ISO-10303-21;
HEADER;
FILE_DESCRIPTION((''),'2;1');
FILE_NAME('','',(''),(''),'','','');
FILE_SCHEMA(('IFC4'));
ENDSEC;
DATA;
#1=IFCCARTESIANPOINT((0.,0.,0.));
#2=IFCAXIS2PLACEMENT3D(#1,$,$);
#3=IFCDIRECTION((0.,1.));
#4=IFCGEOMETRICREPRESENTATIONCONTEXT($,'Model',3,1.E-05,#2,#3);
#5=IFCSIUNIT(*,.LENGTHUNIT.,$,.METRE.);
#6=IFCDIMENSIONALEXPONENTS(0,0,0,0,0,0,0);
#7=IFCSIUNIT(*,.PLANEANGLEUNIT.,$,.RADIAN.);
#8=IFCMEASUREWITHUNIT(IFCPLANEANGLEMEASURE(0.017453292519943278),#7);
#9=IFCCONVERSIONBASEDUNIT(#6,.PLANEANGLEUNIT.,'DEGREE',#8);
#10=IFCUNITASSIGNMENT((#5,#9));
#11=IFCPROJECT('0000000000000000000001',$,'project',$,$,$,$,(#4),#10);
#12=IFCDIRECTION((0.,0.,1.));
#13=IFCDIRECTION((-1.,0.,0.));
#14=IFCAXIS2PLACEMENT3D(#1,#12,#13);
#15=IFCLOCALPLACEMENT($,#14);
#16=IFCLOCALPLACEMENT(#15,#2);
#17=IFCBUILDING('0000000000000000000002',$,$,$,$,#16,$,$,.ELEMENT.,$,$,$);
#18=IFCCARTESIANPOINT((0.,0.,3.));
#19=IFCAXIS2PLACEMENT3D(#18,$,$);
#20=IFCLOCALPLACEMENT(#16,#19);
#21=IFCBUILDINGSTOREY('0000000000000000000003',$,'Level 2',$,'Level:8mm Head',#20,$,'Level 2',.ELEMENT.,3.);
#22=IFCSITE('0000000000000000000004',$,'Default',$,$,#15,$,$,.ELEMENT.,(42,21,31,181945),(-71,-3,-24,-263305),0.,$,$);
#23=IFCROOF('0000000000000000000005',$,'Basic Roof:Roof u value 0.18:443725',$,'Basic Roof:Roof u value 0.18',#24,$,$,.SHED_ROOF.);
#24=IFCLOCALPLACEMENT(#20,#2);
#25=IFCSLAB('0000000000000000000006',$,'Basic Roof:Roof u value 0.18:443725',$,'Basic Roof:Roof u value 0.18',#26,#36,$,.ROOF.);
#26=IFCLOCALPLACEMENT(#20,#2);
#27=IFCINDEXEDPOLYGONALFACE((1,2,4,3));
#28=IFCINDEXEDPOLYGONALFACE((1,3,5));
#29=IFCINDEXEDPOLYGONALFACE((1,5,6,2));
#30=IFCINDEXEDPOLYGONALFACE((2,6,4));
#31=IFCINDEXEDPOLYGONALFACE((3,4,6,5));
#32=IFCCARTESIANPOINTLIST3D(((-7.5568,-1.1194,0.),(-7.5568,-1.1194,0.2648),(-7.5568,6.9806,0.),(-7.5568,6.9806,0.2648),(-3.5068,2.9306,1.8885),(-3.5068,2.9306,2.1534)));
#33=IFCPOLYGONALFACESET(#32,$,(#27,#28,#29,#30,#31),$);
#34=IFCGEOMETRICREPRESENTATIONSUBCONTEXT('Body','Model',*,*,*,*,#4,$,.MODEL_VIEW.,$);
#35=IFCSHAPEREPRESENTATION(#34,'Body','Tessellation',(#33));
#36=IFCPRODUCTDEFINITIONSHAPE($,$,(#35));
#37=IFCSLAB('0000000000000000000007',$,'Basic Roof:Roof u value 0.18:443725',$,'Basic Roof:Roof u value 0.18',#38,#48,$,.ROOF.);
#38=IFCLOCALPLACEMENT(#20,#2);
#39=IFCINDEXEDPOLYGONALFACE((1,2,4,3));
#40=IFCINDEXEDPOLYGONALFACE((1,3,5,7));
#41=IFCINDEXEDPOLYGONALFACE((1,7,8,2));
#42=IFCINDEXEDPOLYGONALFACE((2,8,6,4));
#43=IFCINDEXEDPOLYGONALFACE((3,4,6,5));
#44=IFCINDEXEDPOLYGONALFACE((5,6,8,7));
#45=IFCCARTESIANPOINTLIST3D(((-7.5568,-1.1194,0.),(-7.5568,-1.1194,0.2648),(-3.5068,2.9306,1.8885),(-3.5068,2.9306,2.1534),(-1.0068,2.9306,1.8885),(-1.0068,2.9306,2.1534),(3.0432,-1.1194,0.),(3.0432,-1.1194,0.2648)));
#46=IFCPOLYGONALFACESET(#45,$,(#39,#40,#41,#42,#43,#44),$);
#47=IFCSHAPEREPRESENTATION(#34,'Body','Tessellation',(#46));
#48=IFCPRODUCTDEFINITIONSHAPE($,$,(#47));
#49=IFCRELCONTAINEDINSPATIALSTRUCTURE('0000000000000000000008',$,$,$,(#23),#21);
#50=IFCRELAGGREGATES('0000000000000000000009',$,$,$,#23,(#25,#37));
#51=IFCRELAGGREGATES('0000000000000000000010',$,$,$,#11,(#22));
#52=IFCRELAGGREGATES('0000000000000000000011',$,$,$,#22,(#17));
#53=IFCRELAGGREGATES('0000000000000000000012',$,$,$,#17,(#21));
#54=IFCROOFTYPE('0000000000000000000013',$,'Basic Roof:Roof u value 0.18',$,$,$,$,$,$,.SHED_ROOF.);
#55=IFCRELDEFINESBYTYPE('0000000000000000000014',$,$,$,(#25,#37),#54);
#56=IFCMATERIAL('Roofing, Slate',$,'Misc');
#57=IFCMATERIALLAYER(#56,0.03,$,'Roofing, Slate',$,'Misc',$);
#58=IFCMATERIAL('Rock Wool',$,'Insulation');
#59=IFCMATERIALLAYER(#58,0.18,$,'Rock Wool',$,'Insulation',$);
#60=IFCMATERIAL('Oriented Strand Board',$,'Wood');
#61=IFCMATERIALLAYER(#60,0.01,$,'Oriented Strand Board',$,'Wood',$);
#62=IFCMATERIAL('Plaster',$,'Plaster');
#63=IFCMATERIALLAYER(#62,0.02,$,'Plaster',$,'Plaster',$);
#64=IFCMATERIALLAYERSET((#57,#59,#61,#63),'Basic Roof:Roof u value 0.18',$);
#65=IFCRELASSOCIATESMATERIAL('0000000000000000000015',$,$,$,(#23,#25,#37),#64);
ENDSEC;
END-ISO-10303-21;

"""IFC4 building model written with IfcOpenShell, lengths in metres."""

from ifc_helpers import new_model, entity, si_unit, converted_unit, direction, frame, origin, place, context, subcontext, project, spatial, polyline, outline, extrude, material, layer, layer_set, type_object, element, aggregate, save


model = new_model("IFC4")

# Units and contexts
model_context = context("Model", 3, precision=1e-05, world=origin(), true_north=direction((0.0, 1.0)))
body_context = subcontext(model_context, "Body", "Model", "MODEL_VIEW")
ifc_project = project(units=[si_unit("LENGTHUNIT", "METRE"), converted_unit("PLANEANGLEUNIT", "DEGREE", entity("IfcPlaneAngleMeasure", 0.017453292519943278), si_unit("PLANEANGLEUNIT", "RADIAN"), dimensions=[0, 0, 0, 0, 0, 0, 0])], contexts=[model_context])

# Site, building, storey
site_placement = place(None, frame((0.0, 0.0, 0.0), z_axis=(0.0, 0.0, 1.0), x_axis=(-1.0, 0.0, 0.0)))
site = spatial("IfcSite", under=ifc_project, at=site_placement, Name="Default", CompositionType="ELEMENT", RefLatitude=(42, 21, 31, 181945), RefLongitude=(-71, -3, -24, -263305), RefElevation=0.0)
building_placement = place(site_placement, origin())
building = spatial("IfcBuilding", under=site, at=building_placement, CompositionType="ELEMENT")
storey_placement = place(building_placement, frame((0.0, 0.0, 3.0)))
storey = spatial("IfcBuildingStorey", under=building, at=storey_placement, Name="Level 2", ObjectType="Level:8mm Head", LongName="Level 2", CompositionType="ELEMENT", Elevation=3.0)

# Roof, slabs
ifc_material_1 = material(Name="Roofing, Slate", Category="Misc")
ifc_layer_1 = layer(ifc_material_1, 0.03, Name="Roofing, Slate", Category="Misc")
ifc_material_2 = material(Name="Rock Wool", Category="Insulation")
ifc_layer_2 = layer(ifc_material_2, 0.18, Name="Rock Wool", Category="Insulation")
ifc_material_3 = material(Name="Oriented Strand Board", Category="Wood")
ifc_layer_3 = layer(ifc_material_3, 0.01, Name="Oriented Strand Board", Category="Wood")
ifc_material_4 = material(Name="Plaster", Category="Plaster")
ifc_layer_4 = layer(ifc_material_4, 0.02, Name="Plaster", Category="Plaster")
ifc_layer_set = layer_set([ifc_layer_1, ifc_layer_2, ifc_layer_3, ifc_layer_4], Name="Basic Roof:Roof u value 0.18")
roof_placement = place(storey_placement, frame((-7.5568, -1.1194, 0.0)))
roof = element("IfcRoof", 1, at=roof_placement, inside=storey, material=ifc_layer_set, Name="Basic Roof:Roof u value 0.18:443725", ObjectType="Basic Roof:Roof u value 0.18", PredefinedType="SHED_ROOF")
roof_type = type_object("IfcRoofType", Name="Basic Roof:Roof u value 0.18", PredefinedType="SHED_ROOF")
slab_1_placement = place(roof_placement, origin())
slab_1 = element("IfcSlab", 2, at=slab_1_placement, type_object=roof_type, material=ifc_layer_set, Name="Basic Roof:Roof u value 0.18:443725", ObjectType="Basic Roof:Roof u value 0.18", PredefinedType="ROOF", context=body_context, shape_type="SweptSolid", body=[
    extrude(outline(polyline([(-2.2343, 4.05), (-2.2343, -4.05), (2.2343, 0.0), (-2.2343, 4.05)])), frame((2.025, 4.05, 0.9443), z_axis=(-0.422618, 0.0, 0.906308), x_axis=(0.906308, 0.0, 0.422618)), (0.422618, 0.0, 0.906308), 0.2648),
])
slab_2_placement = place(roof_placement, origin())
slab_2 = element("IfcSlab", 3, at=slab_2_placement, type_object=roof_type, material=ifc_layer_set, Name="Basic Roof:Roof u value 0.18:443725", ObjectType="Basic Roof:Roof u value 0.18", PredefinedType="ROOF", context=body_context, shape_type="SweptSolid", body=[
    extrude(outline(polyline([(-5.3, -2.2343), (5.3, -2.2343), (1.25, 2.2343), (-1.25, 2.2343), (-5.3, -2.2343)])), frame((5.3, 2.025, 0.9443), z_axis=(0.0, -0.422618, 0.906308), x_axis=(1.0, 0.0, 0.0)), (0.0, 0.422618, 0.906308), 0.2648),
])
aggregate(roof, [slab_1, slab_2])

save(model, "model.ifc")
